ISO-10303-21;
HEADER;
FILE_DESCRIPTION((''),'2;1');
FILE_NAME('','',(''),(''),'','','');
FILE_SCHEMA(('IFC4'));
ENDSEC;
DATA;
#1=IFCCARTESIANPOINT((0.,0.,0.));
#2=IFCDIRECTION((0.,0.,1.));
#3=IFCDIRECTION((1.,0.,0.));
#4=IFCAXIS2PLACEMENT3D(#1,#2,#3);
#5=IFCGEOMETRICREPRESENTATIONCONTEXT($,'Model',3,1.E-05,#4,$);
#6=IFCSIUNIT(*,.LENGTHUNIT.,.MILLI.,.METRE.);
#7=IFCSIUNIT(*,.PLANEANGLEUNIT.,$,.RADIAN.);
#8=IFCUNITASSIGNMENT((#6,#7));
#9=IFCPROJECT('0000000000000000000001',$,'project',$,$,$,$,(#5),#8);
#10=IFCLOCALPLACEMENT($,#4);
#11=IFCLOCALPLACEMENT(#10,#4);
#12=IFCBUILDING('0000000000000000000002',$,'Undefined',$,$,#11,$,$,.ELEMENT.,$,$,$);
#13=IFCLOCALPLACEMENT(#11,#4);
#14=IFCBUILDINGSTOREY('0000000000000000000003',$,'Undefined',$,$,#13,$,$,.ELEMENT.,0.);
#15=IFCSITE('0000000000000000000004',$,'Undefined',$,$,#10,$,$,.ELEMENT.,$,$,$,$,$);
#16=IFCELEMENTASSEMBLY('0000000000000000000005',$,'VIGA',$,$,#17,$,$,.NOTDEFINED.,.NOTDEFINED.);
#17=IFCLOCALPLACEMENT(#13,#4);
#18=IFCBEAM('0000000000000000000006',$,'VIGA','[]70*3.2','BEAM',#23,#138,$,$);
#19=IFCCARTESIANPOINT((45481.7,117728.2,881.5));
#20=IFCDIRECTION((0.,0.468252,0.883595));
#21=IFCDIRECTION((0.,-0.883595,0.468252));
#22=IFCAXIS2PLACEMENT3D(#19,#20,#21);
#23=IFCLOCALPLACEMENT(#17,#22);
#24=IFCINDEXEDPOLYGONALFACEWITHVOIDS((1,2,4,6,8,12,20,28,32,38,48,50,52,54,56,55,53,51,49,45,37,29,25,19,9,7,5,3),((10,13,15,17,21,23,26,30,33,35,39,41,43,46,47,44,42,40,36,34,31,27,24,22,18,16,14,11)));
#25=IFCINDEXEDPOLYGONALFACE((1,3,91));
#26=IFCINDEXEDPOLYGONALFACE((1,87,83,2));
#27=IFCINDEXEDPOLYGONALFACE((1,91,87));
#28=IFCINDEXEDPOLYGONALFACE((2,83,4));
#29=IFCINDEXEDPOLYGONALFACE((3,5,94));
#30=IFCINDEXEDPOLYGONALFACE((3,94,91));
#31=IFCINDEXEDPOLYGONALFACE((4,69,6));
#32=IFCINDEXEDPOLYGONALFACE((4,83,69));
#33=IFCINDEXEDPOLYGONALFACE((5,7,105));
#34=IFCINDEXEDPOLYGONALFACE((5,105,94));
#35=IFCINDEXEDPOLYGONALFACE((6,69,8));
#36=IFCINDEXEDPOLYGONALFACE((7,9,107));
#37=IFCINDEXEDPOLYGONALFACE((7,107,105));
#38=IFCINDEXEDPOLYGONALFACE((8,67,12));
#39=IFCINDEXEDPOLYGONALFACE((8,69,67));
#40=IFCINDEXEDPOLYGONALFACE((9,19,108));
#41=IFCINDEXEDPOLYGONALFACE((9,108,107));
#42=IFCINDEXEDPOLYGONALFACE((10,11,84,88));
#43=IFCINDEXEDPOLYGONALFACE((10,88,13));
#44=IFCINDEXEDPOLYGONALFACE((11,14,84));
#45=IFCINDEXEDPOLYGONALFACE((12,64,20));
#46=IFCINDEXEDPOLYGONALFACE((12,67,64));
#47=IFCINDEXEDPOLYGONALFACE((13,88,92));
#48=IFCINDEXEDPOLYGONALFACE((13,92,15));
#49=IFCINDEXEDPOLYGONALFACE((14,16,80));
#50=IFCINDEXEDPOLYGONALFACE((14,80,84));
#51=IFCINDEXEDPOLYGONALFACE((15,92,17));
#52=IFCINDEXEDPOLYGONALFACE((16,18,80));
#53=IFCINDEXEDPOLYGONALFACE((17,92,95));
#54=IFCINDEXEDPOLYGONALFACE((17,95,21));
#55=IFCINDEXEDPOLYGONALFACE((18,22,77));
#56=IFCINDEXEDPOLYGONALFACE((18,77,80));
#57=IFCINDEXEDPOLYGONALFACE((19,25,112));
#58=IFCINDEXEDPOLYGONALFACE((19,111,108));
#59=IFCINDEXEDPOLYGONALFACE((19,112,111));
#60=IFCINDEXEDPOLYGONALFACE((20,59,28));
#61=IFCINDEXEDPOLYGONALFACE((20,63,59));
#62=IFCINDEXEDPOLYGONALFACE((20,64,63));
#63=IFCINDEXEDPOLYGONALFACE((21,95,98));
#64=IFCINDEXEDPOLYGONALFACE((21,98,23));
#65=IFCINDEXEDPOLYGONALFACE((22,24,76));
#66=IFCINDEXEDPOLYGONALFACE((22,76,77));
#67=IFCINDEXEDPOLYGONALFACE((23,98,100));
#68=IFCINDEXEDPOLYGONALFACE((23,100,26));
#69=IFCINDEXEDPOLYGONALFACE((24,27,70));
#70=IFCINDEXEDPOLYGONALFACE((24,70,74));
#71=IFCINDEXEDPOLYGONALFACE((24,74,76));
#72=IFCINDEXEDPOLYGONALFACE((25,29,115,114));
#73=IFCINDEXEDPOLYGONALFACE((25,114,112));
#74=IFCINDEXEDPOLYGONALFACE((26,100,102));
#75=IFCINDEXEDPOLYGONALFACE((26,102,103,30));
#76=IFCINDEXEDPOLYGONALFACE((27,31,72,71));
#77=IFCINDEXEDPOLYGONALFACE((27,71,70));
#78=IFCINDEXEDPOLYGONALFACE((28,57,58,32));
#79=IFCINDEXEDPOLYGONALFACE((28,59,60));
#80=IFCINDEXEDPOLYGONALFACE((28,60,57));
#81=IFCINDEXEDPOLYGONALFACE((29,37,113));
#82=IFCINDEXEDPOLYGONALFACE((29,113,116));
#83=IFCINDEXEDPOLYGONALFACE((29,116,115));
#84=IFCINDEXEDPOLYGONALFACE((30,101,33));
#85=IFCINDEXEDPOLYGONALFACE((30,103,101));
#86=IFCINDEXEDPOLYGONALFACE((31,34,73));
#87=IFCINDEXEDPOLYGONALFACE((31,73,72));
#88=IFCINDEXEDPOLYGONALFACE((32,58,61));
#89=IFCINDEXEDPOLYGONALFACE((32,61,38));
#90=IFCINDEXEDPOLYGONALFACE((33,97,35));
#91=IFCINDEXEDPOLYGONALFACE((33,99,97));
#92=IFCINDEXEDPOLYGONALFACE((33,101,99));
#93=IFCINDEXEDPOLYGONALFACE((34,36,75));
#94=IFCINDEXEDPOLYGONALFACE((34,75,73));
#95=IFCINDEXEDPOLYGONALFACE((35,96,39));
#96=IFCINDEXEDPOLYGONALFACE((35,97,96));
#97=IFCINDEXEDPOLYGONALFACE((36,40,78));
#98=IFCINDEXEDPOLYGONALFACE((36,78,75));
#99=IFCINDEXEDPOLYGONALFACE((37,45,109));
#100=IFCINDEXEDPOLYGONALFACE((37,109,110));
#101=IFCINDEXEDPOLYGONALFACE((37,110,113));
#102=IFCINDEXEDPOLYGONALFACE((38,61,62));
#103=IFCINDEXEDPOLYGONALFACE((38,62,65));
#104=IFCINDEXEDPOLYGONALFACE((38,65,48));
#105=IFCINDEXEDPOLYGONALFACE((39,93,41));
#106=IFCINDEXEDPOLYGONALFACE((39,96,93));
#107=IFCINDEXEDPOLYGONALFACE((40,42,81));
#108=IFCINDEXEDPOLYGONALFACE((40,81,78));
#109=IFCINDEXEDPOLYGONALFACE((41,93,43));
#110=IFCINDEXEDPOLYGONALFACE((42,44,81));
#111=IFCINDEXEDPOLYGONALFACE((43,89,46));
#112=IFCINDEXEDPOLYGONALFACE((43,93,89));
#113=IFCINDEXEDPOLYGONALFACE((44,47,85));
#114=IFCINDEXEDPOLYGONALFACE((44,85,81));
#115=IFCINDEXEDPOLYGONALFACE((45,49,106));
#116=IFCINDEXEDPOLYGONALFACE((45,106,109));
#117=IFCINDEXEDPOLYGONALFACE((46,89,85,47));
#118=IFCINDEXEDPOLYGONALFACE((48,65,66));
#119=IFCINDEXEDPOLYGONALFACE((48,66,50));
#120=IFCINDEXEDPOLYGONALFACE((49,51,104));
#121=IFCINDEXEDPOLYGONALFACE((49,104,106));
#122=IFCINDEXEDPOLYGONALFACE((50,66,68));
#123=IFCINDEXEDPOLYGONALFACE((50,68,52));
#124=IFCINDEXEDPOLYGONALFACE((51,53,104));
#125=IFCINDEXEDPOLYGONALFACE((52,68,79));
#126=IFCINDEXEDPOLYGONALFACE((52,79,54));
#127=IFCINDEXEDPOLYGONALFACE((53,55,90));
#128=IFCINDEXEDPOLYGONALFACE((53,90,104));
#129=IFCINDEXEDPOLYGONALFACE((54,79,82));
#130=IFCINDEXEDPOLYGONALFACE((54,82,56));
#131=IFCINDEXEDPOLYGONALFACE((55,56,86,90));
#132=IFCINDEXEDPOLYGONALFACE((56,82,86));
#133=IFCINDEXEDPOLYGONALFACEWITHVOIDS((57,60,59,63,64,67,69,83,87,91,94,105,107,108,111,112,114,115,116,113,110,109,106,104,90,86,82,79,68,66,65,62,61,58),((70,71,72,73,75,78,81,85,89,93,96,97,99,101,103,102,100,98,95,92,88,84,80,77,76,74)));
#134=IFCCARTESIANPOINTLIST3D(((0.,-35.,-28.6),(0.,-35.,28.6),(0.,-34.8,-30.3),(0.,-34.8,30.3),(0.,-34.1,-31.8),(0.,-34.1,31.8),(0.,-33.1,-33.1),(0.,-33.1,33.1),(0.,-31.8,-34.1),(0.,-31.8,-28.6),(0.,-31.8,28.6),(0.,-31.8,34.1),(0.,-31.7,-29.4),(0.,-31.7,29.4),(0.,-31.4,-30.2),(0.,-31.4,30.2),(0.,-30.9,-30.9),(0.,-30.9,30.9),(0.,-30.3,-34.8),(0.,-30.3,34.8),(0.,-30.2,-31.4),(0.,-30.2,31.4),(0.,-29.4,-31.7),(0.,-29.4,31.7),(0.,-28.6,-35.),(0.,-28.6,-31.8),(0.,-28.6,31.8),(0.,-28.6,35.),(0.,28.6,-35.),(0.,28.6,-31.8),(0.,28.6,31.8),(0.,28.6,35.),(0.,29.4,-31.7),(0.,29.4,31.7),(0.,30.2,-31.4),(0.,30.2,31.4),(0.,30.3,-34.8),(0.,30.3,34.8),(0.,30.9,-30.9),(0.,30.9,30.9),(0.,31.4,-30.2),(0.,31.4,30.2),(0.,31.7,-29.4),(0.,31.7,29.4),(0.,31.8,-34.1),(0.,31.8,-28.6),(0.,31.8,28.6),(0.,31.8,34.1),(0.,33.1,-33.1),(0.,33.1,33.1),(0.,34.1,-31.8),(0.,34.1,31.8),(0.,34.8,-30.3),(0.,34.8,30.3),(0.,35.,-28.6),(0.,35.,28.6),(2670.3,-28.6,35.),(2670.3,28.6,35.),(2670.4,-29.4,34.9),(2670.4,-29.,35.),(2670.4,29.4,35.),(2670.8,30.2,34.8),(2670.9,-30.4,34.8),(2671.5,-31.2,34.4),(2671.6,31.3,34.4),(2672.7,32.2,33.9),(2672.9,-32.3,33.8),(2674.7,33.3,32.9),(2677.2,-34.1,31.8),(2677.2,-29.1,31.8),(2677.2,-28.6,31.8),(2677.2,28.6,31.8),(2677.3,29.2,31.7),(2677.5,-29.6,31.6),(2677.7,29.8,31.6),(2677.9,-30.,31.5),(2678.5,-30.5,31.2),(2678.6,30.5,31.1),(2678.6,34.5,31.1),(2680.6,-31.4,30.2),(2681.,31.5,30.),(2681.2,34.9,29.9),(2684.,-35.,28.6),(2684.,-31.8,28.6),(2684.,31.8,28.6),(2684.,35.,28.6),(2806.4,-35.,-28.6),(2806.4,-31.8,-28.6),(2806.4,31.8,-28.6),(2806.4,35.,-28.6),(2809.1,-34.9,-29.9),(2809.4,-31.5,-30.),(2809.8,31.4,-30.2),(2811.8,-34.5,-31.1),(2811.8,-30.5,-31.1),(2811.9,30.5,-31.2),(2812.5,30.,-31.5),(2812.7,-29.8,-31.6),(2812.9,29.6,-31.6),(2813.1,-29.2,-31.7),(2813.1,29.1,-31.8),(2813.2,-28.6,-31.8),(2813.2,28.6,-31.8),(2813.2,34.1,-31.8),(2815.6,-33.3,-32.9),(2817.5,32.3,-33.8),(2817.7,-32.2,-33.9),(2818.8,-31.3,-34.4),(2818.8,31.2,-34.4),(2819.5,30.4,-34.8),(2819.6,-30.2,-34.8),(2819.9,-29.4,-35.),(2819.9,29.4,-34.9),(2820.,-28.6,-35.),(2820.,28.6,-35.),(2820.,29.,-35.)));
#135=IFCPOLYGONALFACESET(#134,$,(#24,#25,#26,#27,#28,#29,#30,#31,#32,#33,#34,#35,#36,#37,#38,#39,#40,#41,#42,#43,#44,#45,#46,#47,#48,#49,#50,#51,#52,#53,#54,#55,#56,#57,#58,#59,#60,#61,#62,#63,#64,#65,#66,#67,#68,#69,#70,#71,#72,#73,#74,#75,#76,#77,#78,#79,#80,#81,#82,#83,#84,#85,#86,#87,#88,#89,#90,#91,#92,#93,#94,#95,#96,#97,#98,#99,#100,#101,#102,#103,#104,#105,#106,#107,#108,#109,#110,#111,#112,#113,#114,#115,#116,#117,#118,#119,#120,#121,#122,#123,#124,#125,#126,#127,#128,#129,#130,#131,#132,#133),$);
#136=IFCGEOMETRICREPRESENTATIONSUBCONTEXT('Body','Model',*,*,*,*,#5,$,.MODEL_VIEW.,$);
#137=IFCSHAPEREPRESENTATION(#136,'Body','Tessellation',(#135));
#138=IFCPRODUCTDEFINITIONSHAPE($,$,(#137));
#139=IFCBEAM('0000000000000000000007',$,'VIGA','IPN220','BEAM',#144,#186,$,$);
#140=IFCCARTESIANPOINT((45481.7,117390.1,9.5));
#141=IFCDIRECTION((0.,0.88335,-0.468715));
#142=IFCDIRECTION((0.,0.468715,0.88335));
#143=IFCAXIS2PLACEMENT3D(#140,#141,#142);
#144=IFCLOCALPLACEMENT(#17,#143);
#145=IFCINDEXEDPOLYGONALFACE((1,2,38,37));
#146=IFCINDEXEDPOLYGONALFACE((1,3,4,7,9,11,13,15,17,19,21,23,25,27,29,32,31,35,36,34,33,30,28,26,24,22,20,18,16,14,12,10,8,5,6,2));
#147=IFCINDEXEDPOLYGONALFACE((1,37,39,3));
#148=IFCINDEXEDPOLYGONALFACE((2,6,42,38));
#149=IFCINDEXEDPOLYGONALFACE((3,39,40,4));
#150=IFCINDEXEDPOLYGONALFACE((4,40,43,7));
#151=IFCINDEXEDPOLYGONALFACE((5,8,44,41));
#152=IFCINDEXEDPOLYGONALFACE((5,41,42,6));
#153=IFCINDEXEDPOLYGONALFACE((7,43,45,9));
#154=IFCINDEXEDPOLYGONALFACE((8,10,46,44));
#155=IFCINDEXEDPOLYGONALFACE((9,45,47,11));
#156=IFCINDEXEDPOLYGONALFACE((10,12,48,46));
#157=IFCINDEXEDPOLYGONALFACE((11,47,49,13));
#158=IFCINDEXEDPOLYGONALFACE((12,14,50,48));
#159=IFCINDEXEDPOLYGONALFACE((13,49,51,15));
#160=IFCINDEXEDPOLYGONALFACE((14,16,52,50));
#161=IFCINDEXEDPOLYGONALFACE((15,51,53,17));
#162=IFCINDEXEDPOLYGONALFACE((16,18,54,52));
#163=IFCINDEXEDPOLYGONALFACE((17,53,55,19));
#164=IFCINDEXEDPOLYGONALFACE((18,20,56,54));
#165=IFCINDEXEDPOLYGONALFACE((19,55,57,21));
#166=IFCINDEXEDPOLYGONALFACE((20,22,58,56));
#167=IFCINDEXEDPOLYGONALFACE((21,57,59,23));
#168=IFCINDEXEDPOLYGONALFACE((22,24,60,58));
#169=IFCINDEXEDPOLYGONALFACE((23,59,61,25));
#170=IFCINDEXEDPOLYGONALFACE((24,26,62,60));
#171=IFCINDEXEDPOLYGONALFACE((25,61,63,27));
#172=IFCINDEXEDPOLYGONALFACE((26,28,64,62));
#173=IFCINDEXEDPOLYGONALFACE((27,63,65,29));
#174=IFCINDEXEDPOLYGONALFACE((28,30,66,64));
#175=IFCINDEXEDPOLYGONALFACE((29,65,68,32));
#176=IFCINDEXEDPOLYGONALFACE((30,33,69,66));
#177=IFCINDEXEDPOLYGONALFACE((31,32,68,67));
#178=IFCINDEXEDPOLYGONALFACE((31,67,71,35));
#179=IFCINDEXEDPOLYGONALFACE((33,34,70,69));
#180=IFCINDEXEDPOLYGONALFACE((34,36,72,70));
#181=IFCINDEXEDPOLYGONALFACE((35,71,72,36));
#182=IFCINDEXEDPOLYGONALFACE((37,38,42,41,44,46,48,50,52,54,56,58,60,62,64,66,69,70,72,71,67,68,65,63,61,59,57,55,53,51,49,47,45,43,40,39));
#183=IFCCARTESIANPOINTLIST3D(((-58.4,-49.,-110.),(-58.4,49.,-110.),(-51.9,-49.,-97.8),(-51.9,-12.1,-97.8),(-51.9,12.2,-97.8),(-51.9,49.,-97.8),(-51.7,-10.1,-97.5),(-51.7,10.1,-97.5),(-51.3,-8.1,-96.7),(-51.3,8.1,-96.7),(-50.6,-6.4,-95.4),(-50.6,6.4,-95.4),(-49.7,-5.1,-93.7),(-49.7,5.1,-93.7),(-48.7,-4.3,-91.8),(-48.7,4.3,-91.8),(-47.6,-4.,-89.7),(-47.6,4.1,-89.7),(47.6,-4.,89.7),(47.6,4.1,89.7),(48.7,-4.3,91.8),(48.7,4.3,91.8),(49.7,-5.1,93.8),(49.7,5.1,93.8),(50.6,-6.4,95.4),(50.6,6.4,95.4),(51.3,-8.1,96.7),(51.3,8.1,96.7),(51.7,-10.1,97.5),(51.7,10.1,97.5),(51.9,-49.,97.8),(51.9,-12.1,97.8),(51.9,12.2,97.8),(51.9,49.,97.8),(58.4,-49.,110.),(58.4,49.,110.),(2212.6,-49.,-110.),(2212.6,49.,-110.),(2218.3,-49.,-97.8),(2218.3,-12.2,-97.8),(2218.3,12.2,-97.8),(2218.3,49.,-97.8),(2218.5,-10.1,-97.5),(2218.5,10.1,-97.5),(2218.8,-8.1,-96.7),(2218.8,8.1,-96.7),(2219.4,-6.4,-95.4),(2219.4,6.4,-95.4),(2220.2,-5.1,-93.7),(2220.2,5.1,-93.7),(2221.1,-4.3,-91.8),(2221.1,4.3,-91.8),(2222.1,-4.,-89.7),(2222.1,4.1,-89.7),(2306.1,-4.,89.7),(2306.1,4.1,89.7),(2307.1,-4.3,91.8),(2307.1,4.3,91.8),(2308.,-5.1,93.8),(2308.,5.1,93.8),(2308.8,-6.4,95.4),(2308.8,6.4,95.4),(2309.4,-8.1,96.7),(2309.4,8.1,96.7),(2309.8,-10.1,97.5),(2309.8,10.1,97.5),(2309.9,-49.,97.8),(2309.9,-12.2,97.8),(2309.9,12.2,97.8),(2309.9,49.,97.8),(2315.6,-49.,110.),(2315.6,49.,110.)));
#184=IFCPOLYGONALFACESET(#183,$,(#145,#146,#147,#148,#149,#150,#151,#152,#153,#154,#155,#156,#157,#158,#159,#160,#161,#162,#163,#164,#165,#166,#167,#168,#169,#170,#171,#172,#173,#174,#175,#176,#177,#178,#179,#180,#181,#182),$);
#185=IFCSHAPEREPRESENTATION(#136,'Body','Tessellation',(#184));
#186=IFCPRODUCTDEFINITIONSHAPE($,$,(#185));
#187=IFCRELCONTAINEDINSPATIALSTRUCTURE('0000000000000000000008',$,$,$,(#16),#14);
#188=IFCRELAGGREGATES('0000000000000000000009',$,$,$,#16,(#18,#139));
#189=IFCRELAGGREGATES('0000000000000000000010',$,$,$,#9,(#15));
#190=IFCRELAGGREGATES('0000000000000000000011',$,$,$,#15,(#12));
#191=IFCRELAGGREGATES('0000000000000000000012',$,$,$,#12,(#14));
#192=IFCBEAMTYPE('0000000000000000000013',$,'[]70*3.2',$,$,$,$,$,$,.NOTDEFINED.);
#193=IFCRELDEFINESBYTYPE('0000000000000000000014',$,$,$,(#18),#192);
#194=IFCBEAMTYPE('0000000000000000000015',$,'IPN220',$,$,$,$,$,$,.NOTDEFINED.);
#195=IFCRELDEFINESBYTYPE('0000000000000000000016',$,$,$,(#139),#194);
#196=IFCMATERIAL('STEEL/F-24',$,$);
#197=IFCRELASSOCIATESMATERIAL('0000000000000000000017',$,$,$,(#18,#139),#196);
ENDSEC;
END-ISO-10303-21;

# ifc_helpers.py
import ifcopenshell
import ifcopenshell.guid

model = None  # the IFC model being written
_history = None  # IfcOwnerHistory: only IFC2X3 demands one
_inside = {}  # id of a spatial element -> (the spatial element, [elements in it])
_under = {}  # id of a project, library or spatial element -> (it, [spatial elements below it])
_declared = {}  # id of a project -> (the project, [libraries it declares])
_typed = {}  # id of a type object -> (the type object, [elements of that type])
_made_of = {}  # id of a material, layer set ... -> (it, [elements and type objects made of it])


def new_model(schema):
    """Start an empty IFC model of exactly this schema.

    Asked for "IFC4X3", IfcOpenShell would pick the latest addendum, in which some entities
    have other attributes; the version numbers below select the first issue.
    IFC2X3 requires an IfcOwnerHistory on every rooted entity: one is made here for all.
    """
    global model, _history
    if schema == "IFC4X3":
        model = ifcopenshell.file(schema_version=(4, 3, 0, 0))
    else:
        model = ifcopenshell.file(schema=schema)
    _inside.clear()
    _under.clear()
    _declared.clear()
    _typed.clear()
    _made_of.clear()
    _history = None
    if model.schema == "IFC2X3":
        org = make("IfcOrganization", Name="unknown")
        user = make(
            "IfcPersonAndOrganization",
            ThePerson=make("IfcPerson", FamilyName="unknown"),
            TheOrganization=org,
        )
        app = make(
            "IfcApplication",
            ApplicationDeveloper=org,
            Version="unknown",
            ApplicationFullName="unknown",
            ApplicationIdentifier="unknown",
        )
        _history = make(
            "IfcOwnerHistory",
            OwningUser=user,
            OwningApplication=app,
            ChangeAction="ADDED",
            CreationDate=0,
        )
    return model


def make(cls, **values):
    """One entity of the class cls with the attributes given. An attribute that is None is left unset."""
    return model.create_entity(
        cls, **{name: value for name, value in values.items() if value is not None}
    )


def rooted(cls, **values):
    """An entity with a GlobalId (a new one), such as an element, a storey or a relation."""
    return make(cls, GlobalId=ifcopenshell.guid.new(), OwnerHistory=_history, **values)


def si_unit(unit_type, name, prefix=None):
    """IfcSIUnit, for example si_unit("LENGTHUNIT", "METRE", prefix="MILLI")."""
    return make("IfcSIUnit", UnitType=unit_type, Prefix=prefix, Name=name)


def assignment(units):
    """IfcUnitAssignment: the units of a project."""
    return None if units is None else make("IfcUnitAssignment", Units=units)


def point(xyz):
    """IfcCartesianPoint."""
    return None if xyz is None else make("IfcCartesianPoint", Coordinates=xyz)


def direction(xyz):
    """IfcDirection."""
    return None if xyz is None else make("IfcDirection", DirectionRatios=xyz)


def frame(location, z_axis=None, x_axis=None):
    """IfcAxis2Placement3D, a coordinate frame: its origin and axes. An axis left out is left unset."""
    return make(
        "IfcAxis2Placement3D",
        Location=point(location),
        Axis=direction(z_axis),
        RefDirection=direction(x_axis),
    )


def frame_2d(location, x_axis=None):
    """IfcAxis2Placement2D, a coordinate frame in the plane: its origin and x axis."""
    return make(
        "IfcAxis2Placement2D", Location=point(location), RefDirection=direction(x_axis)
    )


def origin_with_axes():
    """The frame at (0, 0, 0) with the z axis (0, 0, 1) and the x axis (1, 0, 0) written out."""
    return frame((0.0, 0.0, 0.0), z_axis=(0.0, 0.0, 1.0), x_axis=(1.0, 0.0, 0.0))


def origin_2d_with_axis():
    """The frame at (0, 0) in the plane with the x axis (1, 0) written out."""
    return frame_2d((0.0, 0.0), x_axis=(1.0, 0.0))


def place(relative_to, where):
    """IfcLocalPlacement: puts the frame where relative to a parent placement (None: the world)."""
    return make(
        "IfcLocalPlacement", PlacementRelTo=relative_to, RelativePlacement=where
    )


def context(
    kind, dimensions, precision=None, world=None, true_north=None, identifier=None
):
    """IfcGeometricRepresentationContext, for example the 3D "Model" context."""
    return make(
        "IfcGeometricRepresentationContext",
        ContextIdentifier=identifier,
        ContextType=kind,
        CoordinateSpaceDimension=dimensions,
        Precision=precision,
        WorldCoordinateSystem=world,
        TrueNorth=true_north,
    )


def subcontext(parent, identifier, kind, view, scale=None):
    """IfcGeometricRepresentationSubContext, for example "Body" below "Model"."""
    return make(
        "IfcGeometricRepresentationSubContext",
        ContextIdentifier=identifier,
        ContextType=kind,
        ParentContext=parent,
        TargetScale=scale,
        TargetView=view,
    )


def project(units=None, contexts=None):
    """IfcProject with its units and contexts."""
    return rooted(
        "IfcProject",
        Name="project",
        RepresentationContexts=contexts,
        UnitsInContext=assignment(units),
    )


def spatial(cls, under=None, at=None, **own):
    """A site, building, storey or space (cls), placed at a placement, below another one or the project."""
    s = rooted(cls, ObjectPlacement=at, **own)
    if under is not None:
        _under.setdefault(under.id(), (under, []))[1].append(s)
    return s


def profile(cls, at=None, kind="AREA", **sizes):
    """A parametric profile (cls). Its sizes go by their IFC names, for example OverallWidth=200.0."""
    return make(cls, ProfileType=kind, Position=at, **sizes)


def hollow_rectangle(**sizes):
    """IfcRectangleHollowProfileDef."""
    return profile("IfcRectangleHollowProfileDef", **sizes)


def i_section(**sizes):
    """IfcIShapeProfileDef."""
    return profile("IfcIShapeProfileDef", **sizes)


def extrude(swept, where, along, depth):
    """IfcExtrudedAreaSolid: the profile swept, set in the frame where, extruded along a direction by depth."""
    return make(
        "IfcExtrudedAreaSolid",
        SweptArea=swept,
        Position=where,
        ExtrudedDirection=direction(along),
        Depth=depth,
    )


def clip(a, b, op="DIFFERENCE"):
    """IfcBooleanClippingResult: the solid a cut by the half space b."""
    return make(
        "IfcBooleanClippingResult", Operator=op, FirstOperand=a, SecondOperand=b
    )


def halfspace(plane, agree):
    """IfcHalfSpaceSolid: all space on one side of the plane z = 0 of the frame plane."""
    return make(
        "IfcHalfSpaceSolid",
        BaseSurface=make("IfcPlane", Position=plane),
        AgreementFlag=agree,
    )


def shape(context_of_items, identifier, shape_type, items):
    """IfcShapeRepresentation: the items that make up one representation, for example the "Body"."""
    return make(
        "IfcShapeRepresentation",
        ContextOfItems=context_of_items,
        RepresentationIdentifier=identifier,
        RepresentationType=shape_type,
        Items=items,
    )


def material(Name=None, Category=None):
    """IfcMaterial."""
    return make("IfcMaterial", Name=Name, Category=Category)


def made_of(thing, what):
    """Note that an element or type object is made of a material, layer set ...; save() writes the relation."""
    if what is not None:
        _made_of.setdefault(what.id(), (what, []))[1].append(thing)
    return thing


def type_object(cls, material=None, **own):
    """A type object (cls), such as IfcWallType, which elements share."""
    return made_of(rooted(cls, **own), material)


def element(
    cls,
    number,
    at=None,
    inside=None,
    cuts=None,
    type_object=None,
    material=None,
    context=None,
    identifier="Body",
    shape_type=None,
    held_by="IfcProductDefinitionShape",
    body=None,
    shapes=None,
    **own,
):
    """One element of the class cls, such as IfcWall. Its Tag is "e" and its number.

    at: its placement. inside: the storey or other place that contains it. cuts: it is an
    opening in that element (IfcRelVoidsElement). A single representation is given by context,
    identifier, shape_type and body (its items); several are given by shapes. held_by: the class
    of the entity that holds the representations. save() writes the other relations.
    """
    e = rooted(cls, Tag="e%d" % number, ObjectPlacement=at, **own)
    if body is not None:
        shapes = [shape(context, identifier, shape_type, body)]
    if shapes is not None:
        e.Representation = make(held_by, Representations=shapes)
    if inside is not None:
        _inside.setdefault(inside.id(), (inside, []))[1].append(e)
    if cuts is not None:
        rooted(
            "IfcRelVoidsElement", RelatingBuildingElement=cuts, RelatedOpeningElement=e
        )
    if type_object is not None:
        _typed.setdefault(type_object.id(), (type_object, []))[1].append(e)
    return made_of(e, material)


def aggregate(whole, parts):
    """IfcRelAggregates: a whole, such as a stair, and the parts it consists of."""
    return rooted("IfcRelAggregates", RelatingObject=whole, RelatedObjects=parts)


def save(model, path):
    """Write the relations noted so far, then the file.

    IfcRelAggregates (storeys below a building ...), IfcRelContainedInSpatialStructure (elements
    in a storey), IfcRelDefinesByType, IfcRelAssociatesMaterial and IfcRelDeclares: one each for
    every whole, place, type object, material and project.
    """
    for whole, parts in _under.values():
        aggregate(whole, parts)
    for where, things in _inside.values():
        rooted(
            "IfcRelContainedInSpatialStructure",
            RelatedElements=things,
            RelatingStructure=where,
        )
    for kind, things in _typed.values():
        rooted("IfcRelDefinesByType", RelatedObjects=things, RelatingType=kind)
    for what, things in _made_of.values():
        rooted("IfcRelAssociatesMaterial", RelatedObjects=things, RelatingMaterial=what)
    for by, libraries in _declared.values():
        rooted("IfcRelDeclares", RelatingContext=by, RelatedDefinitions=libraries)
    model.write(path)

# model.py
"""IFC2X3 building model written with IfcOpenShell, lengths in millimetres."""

from ifc_helpers import new_model, si_unit, frame, origin_with_axes, origin_2d_with_axis, place, context, subcontext, project, spatial, hollow_rectangle, i_section, extrude, clip, halfspace, material, type_object, element, aggregate, save


model = new_model("IFC2X3")

# Units and contexts
model_context = context("Model", 3, precision=1e-05, world=origin_with_axes())
body_context = subcontext(model_context, "Body", "Model", "MODEL_VIEW")
ifc_project = project(units=[si_unit("LENGTHUNIT", "METRE", prefix="MILLI"), si_unit("PLANEANGLEUNIT", "RADIAN")], contexts=[model_context])

# Site, building, storey
site_placement = place(None, origin_with_axes())
site = spatial("IfcSite", under=ifc_project, at=site_placement, Name="Undefined", CompositionType="ELEMENT")
building_placement = place(site_placement, origin_with_axes())
building = spatial("IfcBuilding", under=site, at=building_placement, Name="Undefined", CompositionType="ELEMENT")
storey_placement = place(building_placement, origin_with_axes())
storey = spatial("IfcBuildingStorey", under=building, at=storey_placement, Name="Undefined", CompositionType="ELEMENT", Elevation=0.0)

# Element assembly, beams
assembly_1_placement = place(storey_placement, origin_with_axes())
assembly_1 = element("IfcElementAssembly", 1, at=assembly_1_placement, inside=storey, Name="VIGA", AssemblyPlace="NOTDEFINED", PredefinedType="NOTDEFINED")
ifc_material_1 = material(Name="STEEL/F-24")
beam_type_1 = type_object("IfcBeamType", Name="[]70*3.2", PredefinedType="NOTDEFINED")
beam_1_placement = place(assembly_1_placement, frame((45481.7, 117728.2, 881.5), z_axis=(0.0, 0.468252, 0.883595), x_axis=(0.0, -0.883595, 0.468252)))
beam_1 = element("IfcBeam", 2, at=beam_1_placement, type_object=beam_type_1, material=ifc_material_1, Name="VIGA", Description="[]70*3.2", ObjectType="BEAM", context=body_context, shape_type="Clipping", body=[
    clip(extrude(hollow_rectangle(XDim=70.0, YDim=70.0, WallThickness=3.2, InnerFilletRadius=3.2, OuterFilletRadius=6.4, at=origin_2d_with_axis()), frame((2850.0, 0.0, 0.0), z_axis=(-1.0, 0.0, 0.0), x_axis=(0.0, -1.0, 0.0)), (0.0, 0.0, 1.0), 2850.0), halfspace(frame((2745.2, 0.0, 0.0), z_axis=(-0.423531, 0.0, -0.905881), x_axis=(0.905881, 0.0, -0.423531)), True)),
])
beam_type_2 = type_object("IfcBeamType", Name="IPN220", PredefinedType="NOTDEFINED")
beam_2_placement = place(assembly_1_placement, frame((45481.7, 117390.1, 9.5), z_axis=(0.0, 0.88335, -0.468715), x_axis=(0.0, 0.468715, 0.88335)))
beam_2 = element("IfcBeam", 3, at=beam_2_placement, type_object=beam_type_2, material=ifc_material_1, Name="VIGA", Description="IPN220", ObjectType="BEAM", context=body_context, shape_type="Clipping", body=[
    clip(clip(extrude(i_section(OverallWidth=98.0, OverallDepth=220.0, WebThickness=8.1, FlangeThickness=12.2, FilletRadius=8.1, at=origin_2d_with_axis()), frame((2385.9, 0.0, 0.0), z_axis=(-1.0, 0.0, 0.0), x_axis=(0.0, -1.0, 0.0)), (0.0, 0.0, 1.0), 2507.7), halfspace(frame((2264.1, 0.0, 0.0), z_axis=(-0.905659, 0.0, 0.424006), x_axis=(0.424006, 0.0, 0.905659)), True)), halfspace(frame((0.0, 0.0, 0.0), z_axis=(-0.88335, 0.0, 0.468715), x_axis=(-0.468715, 0.0, -0.88335)), False)),
])

aggregate(assembly_1, [beam_1, beam_2])

save(model, "model.ifc")
